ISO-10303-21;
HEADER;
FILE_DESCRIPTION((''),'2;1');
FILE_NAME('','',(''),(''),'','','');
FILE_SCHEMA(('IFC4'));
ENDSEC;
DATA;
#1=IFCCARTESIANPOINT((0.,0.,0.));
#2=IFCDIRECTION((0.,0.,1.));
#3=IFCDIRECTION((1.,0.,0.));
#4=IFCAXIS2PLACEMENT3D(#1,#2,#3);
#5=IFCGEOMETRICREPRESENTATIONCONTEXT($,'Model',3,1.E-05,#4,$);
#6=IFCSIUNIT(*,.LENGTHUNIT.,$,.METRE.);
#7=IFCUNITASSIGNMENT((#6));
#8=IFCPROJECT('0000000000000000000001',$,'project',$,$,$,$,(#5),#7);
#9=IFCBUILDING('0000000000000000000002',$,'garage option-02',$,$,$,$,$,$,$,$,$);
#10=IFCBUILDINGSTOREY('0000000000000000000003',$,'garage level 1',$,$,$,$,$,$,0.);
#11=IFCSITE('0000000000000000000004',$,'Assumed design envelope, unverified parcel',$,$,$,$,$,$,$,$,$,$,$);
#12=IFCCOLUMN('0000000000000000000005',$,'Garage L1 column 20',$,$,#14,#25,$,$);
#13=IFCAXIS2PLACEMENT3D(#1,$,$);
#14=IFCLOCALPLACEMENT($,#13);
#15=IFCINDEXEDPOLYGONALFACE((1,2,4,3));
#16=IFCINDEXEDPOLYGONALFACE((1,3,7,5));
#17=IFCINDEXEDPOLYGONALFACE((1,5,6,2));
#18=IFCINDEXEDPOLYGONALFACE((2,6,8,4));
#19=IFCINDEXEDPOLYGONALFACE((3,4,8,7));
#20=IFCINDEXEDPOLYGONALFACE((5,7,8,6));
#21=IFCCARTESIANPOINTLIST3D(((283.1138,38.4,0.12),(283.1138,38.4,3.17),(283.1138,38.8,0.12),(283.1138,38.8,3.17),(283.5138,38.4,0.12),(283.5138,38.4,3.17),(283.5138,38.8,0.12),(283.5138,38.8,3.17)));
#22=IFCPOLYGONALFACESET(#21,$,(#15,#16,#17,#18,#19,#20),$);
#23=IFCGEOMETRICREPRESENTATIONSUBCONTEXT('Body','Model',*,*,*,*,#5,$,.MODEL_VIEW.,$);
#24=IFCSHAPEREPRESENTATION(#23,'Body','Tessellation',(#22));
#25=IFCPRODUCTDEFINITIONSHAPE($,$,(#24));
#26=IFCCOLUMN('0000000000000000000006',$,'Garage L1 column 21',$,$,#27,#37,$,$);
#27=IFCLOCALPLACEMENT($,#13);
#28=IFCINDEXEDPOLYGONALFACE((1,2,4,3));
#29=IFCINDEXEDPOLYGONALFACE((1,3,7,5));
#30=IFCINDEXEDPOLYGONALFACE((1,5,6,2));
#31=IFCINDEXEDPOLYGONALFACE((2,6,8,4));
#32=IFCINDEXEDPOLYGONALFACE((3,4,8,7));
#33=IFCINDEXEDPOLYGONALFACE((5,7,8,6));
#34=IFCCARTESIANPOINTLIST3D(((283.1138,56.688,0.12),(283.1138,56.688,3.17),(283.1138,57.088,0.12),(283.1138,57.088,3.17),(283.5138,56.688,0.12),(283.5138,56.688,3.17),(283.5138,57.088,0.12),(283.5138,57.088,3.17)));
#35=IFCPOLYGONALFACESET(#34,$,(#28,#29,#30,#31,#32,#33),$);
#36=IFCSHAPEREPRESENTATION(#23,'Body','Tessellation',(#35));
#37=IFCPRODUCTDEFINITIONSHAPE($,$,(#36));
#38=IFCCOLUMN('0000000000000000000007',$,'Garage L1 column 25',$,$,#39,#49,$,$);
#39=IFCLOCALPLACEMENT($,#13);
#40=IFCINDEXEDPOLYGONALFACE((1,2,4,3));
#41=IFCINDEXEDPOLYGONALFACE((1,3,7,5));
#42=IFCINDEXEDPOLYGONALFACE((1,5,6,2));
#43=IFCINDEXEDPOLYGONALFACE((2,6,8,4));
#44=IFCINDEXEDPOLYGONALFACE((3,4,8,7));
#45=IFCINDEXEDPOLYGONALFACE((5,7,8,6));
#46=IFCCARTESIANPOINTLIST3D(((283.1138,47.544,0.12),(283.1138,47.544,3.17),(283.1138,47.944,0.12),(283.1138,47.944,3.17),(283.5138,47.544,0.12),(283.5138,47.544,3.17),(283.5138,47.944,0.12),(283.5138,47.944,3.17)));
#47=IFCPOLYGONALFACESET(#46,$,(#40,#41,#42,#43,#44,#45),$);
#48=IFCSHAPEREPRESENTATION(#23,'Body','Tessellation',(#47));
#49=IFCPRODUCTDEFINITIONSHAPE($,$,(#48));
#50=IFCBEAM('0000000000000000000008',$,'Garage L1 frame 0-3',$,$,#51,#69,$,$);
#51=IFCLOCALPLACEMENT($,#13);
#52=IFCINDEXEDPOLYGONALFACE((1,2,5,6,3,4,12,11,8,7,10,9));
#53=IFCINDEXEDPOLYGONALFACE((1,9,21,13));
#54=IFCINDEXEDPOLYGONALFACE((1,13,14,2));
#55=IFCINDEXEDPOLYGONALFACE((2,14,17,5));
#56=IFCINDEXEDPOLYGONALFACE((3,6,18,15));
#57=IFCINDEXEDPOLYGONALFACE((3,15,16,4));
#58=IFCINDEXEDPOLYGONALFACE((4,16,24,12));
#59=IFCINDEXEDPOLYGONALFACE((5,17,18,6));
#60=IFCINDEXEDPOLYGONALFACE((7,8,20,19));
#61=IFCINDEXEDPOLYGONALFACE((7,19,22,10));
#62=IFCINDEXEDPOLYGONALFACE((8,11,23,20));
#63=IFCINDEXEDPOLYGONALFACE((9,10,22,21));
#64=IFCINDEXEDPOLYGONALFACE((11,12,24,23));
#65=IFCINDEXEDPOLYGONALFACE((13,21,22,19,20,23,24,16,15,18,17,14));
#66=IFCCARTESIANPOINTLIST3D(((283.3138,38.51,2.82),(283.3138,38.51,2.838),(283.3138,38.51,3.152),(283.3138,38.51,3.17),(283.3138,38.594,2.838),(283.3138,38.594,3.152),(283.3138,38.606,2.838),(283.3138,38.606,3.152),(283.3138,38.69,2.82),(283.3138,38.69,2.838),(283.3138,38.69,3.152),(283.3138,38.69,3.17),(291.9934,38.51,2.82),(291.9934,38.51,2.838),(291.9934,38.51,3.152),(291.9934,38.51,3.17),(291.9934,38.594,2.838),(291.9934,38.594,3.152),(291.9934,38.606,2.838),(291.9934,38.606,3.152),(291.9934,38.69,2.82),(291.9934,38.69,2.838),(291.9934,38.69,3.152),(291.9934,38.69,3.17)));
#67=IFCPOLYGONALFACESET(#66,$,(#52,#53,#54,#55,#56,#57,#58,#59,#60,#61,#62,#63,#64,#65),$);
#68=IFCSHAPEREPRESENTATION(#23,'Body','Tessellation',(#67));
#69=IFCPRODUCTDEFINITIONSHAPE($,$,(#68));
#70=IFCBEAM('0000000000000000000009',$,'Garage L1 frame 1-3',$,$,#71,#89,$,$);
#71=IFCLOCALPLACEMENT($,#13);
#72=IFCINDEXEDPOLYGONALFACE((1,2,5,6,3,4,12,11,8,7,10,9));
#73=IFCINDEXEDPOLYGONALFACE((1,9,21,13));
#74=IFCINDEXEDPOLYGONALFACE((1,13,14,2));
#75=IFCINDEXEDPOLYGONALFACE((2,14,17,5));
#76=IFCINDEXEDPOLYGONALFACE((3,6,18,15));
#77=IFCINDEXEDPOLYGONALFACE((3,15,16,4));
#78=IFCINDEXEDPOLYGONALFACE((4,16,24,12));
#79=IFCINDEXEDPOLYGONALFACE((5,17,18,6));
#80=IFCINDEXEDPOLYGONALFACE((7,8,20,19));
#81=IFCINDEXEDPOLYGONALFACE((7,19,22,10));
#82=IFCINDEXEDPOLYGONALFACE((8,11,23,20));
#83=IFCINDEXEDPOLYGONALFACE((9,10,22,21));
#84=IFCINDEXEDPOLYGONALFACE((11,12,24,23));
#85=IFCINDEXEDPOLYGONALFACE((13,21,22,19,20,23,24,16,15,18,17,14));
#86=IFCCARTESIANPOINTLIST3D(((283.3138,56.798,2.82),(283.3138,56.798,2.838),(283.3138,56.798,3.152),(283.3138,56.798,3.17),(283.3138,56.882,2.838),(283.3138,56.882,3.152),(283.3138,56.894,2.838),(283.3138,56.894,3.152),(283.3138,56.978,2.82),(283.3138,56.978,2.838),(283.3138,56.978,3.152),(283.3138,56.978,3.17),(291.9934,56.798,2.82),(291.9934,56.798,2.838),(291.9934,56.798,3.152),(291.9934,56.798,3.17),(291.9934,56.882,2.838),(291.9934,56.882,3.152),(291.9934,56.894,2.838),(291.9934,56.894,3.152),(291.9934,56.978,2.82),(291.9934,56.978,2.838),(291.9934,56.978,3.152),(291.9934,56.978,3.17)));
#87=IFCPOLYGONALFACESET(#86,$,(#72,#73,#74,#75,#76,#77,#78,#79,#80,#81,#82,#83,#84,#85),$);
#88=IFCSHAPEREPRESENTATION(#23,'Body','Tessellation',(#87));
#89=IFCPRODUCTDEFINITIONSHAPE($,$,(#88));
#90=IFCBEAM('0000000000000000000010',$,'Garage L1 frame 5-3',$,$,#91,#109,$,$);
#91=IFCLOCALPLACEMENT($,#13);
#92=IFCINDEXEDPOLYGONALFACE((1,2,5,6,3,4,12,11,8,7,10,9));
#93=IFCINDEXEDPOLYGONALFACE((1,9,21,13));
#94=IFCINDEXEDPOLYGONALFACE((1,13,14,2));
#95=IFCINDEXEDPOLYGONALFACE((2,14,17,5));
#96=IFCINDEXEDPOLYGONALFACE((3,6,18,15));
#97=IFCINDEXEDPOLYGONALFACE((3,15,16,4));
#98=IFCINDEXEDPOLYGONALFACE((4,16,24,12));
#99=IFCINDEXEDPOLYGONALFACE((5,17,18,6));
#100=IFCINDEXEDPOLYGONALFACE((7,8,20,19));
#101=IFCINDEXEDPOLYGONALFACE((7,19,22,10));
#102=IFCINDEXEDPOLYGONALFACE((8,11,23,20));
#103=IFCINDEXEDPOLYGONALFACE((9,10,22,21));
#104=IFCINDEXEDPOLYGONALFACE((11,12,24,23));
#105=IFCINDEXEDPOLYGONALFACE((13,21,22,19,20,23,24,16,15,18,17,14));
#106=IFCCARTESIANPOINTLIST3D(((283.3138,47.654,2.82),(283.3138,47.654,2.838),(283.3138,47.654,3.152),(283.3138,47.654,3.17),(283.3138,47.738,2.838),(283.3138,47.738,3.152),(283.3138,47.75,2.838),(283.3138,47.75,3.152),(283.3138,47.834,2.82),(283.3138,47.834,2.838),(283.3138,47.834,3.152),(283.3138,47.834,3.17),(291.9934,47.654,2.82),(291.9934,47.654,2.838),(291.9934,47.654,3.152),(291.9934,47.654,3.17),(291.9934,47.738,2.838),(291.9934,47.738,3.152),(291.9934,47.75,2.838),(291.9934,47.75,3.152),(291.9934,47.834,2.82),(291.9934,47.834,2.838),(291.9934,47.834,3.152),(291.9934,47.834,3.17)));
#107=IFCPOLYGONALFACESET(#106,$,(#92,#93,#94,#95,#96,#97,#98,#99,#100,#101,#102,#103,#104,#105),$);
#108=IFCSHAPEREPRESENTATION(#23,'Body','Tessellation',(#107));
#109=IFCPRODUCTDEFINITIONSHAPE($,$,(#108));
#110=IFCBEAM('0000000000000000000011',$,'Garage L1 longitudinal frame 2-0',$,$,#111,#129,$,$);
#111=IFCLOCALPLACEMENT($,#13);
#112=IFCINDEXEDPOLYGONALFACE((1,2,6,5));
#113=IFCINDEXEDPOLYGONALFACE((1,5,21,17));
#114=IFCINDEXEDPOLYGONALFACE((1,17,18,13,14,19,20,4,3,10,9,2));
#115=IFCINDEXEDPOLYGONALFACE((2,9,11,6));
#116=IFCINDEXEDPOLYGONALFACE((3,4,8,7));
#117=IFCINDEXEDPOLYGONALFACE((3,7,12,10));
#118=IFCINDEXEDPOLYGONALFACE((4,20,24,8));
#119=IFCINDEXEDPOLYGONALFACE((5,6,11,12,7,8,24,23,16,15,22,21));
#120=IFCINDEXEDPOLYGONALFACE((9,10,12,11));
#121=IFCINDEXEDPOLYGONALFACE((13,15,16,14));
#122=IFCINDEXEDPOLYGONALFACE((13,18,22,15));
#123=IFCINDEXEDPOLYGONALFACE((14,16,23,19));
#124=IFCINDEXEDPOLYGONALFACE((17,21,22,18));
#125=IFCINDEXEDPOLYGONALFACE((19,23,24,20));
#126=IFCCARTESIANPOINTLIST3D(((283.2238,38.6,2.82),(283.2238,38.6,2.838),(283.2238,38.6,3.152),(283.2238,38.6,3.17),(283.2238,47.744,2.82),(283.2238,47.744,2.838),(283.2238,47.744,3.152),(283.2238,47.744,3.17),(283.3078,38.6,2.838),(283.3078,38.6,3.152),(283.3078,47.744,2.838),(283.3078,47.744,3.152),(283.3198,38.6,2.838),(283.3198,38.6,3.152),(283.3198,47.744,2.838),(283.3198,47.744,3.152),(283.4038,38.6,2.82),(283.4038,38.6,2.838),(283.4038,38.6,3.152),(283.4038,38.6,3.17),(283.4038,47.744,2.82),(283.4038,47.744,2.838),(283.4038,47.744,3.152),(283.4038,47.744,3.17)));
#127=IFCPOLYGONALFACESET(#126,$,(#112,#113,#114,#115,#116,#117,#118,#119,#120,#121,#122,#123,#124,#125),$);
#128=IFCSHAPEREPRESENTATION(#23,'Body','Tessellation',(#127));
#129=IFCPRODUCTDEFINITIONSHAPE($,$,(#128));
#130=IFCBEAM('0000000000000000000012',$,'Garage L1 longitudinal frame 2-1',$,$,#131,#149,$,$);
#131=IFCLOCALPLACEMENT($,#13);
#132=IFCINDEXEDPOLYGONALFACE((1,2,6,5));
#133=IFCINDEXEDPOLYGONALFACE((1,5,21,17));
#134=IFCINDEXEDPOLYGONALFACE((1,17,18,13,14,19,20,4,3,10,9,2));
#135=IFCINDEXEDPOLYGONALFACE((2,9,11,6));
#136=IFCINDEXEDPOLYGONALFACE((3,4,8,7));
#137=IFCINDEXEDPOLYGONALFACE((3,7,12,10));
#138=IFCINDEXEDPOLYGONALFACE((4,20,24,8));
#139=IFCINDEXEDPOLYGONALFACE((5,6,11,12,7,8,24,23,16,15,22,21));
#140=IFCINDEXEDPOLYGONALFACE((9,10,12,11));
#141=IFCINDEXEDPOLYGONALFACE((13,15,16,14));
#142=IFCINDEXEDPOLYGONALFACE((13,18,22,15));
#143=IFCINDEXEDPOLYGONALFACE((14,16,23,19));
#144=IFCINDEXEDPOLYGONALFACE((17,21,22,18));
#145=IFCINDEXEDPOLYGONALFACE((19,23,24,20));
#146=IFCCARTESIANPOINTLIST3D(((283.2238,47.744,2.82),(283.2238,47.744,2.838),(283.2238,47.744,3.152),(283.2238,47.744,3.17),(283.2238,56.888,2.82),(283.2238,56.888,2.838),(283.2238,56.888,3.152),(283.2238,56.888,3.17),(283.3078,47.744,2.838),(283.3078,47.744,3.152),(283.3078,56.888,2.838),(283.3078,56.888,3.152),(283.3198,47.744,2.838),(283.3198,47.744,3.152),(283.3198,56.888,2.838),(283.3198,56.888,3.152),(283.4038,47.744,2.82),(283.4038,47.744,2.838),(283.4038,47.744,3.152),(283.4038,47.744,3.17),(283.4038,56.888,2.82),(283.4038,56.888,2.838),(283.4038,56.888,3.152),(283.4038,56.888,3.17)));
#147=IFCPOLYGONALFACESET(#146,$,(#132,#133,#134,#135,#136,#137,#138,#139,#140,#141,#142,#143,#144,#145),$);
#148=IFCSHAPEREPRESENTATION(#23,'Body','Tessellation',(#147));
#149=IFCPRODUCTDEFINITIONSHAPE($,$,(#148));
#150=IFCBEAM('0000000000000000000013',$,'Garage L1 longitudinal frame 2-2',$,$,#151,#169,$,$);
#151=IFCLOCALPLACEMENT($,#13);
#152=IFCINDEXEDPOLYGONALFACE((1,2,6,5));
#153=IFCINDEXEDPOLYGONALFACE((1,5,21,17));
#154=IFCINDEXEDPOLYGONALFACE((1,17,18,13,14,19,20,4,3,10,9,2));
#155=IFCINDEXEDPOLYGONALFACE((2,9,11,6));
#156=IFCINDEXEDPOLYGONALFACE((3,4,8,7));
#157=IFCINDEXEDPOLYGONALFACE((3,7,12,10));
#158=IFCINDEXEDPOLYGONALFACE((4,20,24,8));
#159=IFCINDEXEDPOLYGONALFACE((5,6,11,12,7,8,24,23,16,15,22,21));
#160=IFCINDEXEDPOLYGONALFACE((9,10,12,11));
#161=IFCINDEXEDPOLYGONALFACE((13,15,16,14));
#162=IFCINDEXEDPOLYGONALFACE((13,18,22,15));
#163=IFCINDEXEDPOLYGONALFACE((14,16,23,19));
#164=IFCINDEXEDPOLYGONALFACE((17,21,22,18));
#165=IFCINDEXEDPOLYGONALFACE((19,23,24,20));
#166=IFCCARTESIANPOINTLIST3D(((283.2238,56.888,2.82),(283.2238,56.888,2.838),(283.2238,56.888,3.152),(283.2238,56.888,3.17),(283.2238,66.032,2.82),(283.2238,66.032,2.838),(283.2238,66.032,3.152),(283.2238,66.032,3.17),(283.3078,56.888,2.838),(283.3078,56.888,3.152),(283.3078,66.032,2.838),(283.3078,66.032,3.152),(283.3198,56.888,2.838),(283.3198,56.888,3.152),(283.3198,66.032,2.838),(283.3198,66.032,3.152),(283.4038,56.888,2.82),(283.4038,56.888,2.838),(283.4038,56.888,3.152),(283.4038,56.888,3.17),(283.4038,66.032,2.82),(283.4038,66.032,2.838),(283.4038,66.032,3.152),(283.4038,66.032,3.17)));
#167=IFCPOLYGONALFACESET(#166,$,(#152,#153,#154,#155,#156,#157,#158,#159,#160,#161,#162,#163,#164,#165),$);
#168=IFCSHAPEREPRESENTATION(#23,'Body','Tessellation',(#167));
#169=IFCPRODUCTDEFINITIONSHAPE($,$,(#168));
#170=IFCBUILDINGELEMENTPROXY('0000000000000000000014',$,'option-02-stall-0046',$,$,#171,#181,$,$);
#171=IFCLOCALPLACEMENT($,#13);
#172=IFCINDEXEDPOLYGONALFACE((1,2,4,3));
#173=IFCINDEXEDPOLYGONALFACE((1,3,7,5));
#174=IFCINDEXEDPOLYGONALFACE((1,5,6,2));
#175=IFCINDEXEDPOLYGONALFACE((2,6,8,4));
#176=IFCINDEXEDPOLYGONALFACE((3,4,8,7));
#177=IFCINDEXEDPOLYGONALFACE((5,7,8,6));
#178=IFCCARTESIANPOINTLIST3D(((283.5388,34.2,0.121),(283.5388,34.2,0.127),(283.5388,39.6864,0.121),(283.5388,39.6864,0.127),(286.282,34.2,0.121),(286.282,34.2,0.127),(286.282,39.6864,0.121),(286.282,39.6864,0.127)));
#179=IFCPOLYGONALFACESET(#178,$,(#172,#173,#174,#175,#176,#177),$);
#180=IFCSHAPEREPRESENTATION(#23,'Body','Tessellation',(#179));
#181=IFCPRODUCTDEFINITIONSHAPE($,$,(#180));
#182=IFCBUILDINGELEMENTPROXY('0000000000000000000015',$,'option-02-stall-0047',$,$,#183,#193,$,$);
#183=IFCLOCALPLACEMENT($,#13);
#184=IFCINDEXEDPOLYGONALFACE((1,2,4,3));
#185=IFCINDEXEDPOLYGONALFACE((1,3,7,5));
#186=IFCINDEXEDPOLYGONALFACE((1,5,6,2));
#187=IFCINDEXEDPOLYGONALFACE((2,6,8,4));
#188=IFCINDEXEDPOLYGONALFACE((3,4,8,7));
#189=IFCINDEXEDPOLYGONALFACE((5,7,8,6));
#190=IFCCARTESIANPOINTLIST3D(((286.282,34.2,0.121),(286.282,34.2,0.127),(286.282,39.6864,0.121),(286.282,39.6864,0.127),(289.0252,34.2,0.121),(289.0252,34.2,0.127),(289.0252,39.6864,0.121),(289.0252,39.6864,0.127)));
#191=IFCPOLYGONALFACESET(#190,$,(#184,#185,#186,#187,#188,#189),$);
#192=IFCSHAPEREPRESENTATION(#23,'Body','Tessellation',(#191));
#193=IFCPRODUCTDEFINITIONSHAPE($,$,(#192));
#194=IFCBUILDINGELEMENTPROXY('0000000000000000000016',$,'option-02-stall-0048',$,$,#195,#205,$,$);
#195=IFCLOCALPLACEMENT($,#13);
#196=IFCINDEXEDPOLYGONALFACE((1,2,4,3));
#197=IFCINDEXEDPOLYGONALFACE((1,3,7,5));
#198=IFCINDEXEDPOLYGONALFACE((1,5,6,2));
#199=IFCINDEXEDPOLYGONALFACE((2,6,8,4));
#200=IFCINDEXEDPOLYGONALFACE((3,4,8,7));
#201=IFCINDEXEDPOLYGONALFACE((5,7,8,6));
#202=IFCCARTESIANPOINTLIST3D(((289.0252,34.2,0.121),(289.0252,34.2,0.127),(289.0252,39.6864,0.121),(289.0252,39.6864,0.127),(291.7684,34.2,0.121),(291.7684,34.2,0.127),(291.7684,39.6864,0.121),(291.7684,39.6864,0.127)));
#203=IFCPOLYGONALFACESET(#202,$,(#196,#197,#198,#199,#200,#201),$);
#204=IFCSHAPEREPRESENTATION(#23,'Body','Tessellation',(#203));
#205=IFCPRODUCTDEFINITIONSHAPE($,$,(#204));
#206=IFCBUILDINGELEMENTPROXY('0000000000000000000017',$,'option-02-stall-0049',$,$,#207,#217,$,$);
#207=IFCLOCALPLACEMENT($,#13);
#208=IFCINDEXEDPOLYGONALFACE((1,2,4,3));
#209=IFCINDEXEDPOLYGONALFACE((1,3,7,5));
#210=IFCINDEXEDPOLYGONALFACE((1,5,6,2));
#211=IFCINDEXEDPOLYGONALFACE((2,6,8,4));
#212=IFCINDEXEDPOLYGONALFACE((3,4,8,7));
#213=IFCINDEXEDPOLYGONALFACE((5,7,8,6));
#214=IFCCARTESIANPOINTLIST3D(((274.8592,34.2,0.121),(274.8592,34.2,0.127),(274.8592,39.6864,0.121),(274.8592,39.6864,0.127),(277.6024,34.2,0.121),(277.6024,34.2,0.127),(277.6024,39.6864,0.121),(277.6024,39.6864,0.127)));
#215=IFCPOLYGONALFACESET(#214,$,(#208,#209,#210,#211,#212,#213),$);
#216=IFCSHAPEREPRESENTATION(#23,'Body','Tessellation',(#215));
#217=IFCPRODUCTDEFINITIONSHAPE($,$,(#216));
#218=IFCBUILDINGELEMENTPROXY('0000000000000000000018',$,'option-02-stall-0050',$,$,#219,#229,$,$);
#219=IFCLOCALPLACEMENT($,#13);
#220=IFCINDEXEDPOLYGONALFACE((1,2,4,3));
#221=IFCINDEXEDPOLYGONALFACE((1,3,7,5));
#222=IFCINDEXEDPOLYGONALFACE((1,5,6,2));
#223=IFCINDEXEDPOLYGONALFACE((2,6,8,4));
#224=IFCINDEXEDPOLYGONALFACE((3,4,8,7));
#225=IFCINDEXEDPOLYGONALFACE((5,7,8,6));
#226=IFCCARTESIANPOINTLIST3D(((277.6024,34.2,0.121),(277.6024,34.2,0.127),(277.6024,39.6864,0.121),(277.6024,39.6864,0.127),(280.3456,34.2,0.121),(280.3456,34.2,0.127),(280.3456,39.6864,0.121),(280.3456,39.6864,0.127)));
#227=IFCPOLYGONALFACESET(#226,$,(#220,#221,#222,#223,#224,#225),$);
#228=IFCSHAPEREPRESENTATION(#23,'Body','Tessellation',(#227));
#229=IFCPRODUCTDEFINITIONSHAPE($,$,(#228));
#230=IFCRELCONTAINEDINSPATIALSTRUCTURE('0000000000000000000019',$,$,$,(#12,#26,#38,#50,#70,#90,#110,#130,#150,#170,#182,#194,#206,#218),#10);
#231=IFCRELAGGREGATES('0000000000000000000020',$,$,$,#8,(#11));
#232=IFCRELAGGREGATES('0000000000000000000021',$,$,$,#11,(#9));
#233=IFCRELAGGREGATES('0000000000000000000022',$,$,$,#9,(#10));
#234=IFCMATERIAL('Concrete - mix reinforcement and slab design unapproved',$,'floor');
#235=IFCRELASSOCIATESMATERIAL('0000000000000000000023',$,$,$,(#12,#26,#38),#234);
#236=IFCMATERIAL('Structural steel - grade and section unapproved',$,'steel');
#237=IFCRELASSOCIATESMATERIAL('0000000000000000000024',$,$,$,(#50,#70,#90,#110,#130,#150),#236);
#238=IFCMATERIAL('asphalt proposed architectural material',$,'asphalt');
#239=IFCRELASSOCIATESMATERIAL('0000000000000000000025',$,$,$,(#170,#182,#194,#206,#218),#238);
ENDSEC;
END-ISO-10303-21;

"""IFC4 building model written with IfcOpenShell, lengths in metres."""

from ifc_helpers import new_model, si_unit, frame, origin_with_axes, place, context, subcontext, project, spatial, rectangle, i_section, extrude, material, element, save


model = new_model("IFC4")

# Units and contexts
model_context = context("Model", 3, precision=1e-05, world=origin_with_axes())
body_context = subcontext(model_context, "Body", "Model", "MODEL_VIEW")
ifc_project = project(units=[si_unit("LENGTHUNIT", "METRE")], contexts=[model_context])

# Site, building, storey
site = spatial("IfcSite", under=ifc_project, Name="Assumed design envelope, unverified parcel")
building = spatial("IfcBuilding", under=site, Name="garage option-02")
storey = spatial("IfcBuildingStorey", under=building, Name="garage level 1", Elevation=0.0)

# Columns
ifc_material_1 = material(Name="Concrete - mix reinforcement and slab design unapproved", Category="floor")
for number, where, z_axis, x_axis, name in (
    (1, (283.3138, 38.6, 0.12), (0.0, 0.0, 1.0), (1.0, 0.0, 0.0), "Garage L1 column 20"),
    (2, (283.3138, 56.888, 0.12), (0.0, 0.0, 1.0), (1.0, 0.0, 0.0), "Garage L1 column 21"),
    (3, (283.3138, 47.744, 0.12), (0.0, 0.0, 1.0), (1.0, 0.0, 0.0), "Garage L1 column 25"),
):
    element("IfcColumn", number, at=place(None, frame(where, z_axis=z_axis, x_axis=x_axis)), inside=storey, material=ifc_material_1, Name=name, context=body_context, shape_type="SweptSolid", body=[
        extrude(rectangle(XDim=0.4, YDim=0.4), origin_with_axes(), (0.0, 0.0, 1.0), 3.05),
    ])

# Beams
ifc_material_2 = material(Name="Structural steel - grade and section unapproved", Category="steel")
for number, where, z_axis, x_axis, name in (
    (4, (283.3138, 38.6, 2.995), (1.0, 0.0, 0.0), (0.0, 1.0, 0.0), "Garage L1 frame 0-3"),
    (5, (283.3138, 56.888, 2.995), (1.0, 0.0, 0.0), (0.0, 1.0, 0.0), "Garage L1 frame 1-3"),
    (6, (283.3138, 47.744, 2.995), (1.0, 0.0, 0.0), (0.0, 1.0, 0.0), "Garage L1 frame 5-3"),
):
    element("IfcBeam", number, at=place(None, frame(where, z_axis=z_axis, x_axis=x_axis)), inside=storey, material=ifc_material_2, Name=name, context=body_context, shape_type="SweptSolid", body=[
        extrude(i_section(OverallWidth=0.18, OverallDepth=0.35, WebThickness=0.012, FlangeThickness=0.018, FilletRadius=0.0), origin_with_axes(), (0.0, 0.0, 1.0), 8.6796),
    ])
for number, where, z_axis, x_axis, name in (
    (7, (283.3138, 38.6, 2.995), (0.0, 1.0, 0.0), (-1.0, 0.0, 0.0), "Garage L1 longitudinal frame 2-0"),
    (8, (283.3138, 47.744, 2.995), (0.0, 1.0, 0.0), (-1.0, 0.0, 0.0), "Garage L1 longitudinal frame 2-1"),
):
    element("IfcBeam", number, at=place(None, frame(where, z_axis=z_axis, x_axis=x_axis)), inside=storey, material=ifc_material_2, Name=name, context=body_context, shape_type="SweptSolid", body=[
        extrude(i_section(OverallWidth=0.18, OverallDepth=0.35, WebThickness=0.012, FlangeThickness=0.018, FilletRadius=0.0), origin_with_axes(), (0.0, 0.0, 1.0), 9.144),
    ])
beam_placement = place(None, frame((283.3138, 56.888, 2.995), z_axis=(0.0, 1.0, 0.0), x_axis=(-1.0, 0.0, 0.0)))
element("IfcBeam", 9, at=beam_placement, inside=storey, material=ifc_material_2, Name="Garage L1 longitudinal frame 2-2", context=body_context, shape_type="SweptSolid", body=[
    extrude(i_section(OverallWidth=0.18, OverallDepth=0.35, WebThickness=0.012, FlangeThickness=0.018, FilletRadius=0.0), origin_with_axes(), (0.0, 0.0, 1.0), 9.144),
])

# Building element proxies
ifc_material_3 = material(Name="asphalt proposed architectural material", Category="asphalt")
for number, where, z_axis, x_axis, name in (
    (10, (284.9104, 36.9432, 0.121), (0.0, 0.0, 1.0), (1.0, 0.0, 0.0), "option-02-stall-0046"),
    (11, (287.6536, 36.9432, 0.121), (0.0, 0.0, 1.0), (1.0, 0.0, 0.0), "option-02-stall-0047"),
    (12, (290.3968, 36.9432, 0.121), (0.0, 0.0, 1.0), (1.0, 0.0, 0.0), "option-02-stall-0048"),
    (13, (276.2308, 36.9432, 0.121), (0.0, 0.0, 1.0), (1.0, 0.0, 0.0), "option-02-stall-0049"),
    (14, (278.974, 36.9432, 0.121), (0.0, 0.0, 1.0), (1.0, 0.0, 0.0), "option-02-stall-0050"),
):
    element("IfcBuildingElementProxy", number, at=place(None, frame(where, z_axis=z_axis, x_axis=x_axis)), inside=storey, material=ifc_material_3, Name=name, context=body_context, shape_type="SweptSolid", body=[
        extrude(rectangle(XDim=2.7432, YDim=5.4864), origin_with_axes(), (0.0, 0.0, 1.0), 0.006),
    ])

save(model, "model.ifc")
